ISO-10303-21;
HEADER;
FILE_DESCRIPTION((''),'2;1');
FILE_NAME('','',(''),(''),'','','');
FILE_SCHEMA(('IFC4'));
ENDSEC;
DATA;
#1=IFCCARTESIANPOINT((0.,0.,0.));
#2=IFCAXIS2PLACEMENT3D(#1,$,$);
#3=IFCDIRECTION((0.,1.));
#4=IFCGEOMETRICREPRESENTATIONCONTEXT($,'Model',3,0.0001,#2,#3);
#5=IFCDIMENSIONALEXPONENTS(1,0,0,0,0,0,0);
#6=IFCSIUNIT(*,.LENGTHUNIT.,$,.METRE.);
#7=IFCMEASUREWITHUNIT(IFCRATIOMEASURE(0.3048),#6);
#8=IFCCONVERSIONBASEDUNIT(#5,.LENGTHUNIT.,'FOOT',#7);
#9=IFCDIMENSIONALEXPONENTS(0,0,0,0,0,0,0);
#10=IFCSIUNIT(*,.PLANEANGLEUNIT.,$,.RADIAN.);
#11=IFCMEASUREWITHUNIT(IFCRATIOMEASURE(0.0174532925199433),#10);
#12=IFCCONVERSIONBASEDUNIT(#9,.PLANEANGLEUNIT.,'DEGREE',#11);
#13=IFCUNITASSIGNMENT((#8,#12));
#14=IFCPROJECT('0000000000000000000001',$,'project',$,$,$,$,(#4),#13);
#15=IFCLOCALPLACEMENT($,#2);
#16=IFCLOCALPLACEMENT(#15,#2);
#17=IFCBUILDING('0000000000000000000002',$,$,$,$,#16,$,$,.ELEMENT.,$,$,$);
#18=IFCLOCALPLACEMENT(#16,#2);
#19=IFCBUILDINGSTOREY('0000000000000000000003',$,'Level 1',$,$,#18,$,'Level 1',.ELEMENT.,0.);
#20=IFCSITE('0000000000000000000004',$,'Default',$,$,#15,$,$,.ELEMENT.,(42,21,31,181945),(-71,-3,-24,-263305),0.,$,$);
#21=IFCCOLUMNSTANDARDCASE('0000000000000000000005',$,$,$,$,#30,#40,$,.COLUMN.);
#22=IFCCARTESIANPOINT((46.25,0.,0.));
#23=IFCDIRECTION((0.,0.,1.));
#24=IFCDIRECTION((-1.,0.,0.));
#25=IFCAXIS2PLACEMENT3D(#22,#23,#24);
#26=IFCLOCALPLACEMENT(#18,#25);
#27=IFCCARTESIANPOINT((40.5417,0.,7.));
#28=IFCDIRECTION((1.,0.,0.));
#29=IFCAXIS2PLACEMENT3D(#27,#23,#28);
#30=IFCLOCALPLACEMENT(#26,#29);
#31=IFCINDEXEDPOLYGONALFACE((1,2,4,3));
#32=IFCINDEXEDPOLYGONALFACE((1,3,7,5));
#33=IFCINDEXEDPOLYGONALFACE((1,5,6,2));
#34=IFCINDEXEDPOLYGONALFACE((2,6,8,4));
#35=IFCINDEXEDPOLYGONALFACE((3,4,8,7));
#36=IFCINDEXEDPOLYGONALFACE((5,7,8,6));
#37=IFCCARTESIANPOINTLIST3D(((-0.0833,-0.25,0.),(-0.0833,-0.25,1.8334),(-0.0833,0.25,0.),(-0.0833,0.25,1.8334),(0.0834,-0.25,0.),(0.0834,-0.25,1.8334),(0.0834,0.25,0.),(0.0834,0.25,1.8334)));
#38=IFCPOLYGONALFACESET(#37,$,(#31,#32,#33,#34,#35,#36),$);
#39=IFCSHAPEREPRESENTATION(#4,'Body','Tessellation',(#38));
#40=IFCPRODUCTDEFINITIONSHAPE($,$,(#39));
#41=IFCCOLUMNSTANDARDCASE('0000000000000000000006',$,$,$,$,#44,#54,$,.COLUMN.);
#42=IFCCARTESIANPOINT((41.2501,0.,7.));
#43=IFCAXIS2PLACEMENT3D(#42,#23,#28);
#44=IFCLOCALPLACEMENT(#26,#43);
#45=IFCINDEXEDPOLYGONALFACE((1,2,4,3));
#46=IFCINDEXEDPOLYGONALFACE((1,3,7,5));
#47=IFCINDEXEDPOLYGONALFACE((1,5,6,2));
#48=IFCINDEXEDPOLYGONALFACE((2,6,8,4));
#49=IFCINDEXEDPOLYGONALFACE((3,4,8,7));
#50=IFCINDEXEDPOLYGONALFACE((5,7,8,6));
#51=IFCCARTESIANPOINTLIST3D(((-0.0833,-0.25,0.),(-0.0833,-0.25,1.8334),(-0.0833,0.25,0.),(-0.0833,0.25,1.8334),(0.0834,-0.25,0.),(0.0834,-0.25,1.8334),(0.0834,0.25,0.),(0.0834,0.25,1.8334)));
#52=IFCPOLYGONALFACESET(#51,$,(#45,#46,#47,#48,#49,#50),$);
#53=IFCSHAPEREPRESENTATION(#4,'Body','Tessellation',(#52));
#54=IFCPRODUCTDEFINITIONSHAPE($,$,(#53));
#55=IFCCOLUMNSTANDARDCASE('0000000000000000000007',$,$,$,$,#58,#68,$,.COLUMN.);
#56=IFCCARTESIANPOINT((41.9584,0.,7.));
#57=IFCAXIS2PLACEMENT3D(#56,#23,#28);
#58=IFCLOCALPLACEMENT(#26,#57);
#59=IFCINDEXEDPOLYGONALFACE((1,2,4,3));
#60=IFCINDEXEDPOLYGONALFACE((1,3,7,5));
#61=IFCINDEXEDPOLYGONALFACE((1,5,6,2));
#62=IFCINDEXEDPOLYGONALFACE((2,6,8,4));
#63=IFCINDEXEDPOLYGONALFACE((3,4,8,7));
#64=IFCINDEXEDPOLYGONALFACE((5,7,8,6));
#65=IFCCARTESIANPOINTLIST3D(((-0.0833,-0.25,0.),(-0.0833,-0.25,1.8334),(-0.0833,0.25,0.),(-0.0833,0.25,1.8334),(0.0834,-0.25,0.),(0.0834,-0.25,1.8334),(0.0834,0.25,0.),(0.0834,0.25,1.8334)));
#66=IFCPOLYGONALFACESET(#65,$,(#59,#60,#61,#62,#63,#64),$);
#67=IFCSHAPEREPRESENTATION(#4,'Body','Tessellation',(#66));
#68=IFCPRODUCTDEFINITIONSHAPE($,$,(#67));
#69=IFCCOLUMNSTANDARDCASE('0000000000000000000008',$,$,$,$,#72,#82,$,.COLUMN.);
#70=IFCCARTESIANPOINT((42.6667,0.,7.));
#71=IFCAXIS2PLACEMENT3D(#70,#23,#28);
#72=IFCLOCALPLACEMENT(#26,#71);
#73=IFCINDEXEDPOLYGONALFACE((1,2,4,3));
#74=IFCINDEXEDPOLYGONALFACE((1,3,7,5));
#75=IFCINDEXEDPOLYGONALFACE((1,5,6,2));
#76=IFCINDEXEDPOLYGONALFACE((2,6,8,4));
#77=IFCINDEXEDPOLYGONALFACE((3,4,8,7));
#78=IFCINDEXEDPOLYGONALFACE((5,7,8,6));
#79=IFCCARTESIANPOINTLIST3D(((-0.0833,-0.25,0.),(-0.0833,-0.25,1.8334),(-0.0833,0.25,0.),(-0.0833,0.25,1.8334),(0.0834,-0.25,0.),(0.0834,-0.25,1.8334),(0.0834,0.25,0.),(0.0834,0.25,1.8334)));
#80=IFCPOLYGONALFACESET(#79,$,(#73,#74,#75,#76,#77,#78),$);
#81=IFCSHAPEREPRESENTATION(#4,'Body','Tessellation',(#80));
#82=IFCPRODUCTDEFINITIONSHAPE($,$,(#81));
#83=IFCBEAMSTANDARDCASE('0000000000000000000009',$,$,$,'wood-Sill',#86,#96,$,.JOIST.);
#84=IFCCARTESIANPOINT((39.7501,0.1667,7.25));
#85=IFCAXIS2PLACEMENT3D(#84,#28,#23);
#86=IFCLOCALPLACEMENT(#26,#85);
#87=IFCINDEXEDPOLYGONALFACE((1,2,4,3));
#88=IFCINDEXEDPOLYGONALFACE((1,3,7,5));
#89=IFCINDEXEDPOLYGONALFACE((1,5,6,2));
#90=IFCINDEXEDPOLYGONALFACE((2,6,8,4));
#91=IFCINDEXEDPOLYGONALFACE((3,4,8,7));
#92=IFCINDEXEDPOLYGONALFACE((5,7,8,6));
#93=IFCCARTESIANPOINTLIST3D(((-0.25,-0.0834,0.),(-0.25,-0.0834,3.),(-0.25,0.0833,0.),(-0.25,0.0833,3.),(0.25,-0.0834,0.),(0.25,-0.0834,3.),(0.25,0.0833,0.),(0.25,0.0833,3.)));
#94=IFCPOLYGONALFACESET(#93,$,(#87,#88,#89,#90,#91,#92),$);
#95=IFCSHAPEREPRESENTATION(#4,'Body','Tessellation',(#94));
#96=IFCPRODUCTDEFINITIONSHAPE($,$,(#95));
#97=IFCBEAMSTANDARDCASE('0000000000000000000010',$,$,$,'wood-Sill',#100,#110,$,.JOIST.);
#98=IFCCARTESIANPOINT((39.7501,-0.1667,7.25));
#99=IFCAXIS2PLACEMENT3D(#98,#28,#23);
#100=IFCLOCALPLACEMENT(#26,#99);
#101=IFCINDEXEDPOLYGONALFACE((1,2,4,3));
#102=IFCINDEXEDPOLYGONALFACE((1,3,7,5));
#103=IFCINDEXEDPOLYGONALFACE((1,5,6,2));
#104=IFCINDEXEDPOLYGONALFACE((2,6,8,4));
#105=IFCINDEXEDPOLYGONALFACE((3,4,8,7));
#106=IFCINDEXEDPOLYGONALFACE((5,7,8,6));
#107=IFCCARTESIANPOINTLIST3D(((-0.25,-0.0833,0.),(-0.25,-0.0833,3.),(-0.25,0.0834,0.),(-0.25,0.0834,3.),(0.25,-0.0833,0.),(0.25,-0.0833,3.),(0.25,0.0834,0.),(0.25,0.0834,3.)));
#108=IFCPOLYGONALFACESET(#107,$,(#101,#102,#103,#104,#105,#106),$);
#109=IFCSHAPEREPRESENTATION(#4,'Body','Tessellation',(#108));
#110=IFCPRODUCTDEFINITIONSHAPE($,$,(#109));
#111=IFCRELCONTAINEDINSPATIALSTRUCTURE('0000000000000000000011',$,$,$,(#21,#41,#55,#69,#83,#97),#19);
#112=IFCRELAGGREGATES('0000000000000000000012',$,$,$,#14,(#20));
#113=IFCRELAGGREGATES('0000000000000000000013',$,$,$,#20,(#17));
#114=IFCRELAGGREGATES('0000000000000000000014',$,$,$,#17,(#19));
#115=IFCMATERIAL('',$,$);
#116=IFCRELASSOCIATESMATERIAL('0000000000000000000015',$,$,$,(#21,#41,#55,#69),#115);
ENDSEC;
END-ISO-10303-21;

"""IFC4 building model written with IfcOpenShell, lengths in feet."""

from ifc_helpers import new_model, entity, si_unit, converted_unit, direction, frame, origin, origin_with_axes, place, context, project, spatial, rectangle, extrude, material, element, save


model = new_model("IFC4")

# Units and contexts
model_context = context("Model", 3, precision=0.0001, world=origin(), true_north=direction((0.0, 1.0)))
ifc_project = project(units=[converted_unit("LENGTHUNIT", "FOOT", entity("IfcRatioMeasure", 0.3048), si_unit("LENGTHUNIT", "METRE"), dimensions=[1, 0, 0, 0, 0, 0, 0]), converted_unit("PLANEANGLEUNIT", "DEGREE", entity("IfcRatioMeasure", 0.0174532925199433), si_unit("PLANEANGLEUNIT", "RADIAN"), dimensions=[0, 0, 0, 0, 0, 0, 0])], contexts=[model_context])

# Site, building, storey
site_placement = place(None, origin())
site = spatial("IfcSite", under=ifc_project, at=site_placement, Name="Default", CompositionType="ELEMENT", RefLatitude=(42, 21, 31, 181945), RefLongitude=(-71, -3, -24, -263305), RefElevation=0.0)
building_placement = place(site_placement, origin())
building = spatial("IfcBuilding", under=site, at=building_placement, CompositionType="ELEMENT")
storey_placement = place(building_placement, origin())
storey = spatial("IfcBuildingStorey", under=building, at=storey_placement, Name="Level 1", LongName="Level 1", CompositionType="ELEMENT", Elevation=0.0)

# Columns
placement_1 = place(storey_placement, frame((46.25, 0.0, 0.0), z_axis=(0.0, 0.0, 1.0), x_axis=(-1.0, 0.0, 0.0)))
ifc_material_1 = material(Name="")
for number, where, z_axis, x_axis in (
    (1, (40.5417, 0.0, 7.0), (0.0, 0.0, 1.0), (1.0, 0.0, 0.0)),
    (2, (41.2501, 0.0, 7.0), (0.0, 0.0, 1.0), (1.0, 0.0, 0.0)),
    (3, (41.9584, 0.0, 7.0), (0.0, 0.0, 1.0), (1.0, 0.0, 0.0)),
    (4, (42.6667, 0.0, 7.0), (0.0, 0.0, 1.0), (1.0, 0.0, 0.0)),
):
    element("IfcColumnStandardCase", number, at=place(placement_1, frame(where, z_axis=z_axis, x_axis=x_axis)), inside=storey, material=ifc_material_1, PredefinedType="COLUMN", context=model_context, shape_type="SweptSolid", body=[
        extrude(rectangle(XDim=0.1667, YDim=0.5), origin(), (0.0, 0.0, 1.0), 1.8334),
    ])

# Beams
for number, where, z_axis, x_axis in (
    (5, (39.7501, 0.1667, 7.25), (1.0, 0.0, 0.0), (0.0, 0.0, 1.0)),
    (6, (39.7501, -0.1667, 7.25), (1.0, 0.0, 0.0), (0.0, 0.0, 1.0)),
):
    element("IfcBeamStandardCase", number, at=place(placement_1, frame(where, z_axis=z_axis, x_axis=x_axis)), inside=storey, ObjectType="wood-Sill", PredefinedType="JOIST", context=model_context, shape_type="SweptSolid", body=[
        extrude(rectangle(XDim=0.5, YDim=0.1667), origin_with_axes(), (0.0, 0.0, 1.0), 3.0),
    ])

save(model, "model.ifc")
